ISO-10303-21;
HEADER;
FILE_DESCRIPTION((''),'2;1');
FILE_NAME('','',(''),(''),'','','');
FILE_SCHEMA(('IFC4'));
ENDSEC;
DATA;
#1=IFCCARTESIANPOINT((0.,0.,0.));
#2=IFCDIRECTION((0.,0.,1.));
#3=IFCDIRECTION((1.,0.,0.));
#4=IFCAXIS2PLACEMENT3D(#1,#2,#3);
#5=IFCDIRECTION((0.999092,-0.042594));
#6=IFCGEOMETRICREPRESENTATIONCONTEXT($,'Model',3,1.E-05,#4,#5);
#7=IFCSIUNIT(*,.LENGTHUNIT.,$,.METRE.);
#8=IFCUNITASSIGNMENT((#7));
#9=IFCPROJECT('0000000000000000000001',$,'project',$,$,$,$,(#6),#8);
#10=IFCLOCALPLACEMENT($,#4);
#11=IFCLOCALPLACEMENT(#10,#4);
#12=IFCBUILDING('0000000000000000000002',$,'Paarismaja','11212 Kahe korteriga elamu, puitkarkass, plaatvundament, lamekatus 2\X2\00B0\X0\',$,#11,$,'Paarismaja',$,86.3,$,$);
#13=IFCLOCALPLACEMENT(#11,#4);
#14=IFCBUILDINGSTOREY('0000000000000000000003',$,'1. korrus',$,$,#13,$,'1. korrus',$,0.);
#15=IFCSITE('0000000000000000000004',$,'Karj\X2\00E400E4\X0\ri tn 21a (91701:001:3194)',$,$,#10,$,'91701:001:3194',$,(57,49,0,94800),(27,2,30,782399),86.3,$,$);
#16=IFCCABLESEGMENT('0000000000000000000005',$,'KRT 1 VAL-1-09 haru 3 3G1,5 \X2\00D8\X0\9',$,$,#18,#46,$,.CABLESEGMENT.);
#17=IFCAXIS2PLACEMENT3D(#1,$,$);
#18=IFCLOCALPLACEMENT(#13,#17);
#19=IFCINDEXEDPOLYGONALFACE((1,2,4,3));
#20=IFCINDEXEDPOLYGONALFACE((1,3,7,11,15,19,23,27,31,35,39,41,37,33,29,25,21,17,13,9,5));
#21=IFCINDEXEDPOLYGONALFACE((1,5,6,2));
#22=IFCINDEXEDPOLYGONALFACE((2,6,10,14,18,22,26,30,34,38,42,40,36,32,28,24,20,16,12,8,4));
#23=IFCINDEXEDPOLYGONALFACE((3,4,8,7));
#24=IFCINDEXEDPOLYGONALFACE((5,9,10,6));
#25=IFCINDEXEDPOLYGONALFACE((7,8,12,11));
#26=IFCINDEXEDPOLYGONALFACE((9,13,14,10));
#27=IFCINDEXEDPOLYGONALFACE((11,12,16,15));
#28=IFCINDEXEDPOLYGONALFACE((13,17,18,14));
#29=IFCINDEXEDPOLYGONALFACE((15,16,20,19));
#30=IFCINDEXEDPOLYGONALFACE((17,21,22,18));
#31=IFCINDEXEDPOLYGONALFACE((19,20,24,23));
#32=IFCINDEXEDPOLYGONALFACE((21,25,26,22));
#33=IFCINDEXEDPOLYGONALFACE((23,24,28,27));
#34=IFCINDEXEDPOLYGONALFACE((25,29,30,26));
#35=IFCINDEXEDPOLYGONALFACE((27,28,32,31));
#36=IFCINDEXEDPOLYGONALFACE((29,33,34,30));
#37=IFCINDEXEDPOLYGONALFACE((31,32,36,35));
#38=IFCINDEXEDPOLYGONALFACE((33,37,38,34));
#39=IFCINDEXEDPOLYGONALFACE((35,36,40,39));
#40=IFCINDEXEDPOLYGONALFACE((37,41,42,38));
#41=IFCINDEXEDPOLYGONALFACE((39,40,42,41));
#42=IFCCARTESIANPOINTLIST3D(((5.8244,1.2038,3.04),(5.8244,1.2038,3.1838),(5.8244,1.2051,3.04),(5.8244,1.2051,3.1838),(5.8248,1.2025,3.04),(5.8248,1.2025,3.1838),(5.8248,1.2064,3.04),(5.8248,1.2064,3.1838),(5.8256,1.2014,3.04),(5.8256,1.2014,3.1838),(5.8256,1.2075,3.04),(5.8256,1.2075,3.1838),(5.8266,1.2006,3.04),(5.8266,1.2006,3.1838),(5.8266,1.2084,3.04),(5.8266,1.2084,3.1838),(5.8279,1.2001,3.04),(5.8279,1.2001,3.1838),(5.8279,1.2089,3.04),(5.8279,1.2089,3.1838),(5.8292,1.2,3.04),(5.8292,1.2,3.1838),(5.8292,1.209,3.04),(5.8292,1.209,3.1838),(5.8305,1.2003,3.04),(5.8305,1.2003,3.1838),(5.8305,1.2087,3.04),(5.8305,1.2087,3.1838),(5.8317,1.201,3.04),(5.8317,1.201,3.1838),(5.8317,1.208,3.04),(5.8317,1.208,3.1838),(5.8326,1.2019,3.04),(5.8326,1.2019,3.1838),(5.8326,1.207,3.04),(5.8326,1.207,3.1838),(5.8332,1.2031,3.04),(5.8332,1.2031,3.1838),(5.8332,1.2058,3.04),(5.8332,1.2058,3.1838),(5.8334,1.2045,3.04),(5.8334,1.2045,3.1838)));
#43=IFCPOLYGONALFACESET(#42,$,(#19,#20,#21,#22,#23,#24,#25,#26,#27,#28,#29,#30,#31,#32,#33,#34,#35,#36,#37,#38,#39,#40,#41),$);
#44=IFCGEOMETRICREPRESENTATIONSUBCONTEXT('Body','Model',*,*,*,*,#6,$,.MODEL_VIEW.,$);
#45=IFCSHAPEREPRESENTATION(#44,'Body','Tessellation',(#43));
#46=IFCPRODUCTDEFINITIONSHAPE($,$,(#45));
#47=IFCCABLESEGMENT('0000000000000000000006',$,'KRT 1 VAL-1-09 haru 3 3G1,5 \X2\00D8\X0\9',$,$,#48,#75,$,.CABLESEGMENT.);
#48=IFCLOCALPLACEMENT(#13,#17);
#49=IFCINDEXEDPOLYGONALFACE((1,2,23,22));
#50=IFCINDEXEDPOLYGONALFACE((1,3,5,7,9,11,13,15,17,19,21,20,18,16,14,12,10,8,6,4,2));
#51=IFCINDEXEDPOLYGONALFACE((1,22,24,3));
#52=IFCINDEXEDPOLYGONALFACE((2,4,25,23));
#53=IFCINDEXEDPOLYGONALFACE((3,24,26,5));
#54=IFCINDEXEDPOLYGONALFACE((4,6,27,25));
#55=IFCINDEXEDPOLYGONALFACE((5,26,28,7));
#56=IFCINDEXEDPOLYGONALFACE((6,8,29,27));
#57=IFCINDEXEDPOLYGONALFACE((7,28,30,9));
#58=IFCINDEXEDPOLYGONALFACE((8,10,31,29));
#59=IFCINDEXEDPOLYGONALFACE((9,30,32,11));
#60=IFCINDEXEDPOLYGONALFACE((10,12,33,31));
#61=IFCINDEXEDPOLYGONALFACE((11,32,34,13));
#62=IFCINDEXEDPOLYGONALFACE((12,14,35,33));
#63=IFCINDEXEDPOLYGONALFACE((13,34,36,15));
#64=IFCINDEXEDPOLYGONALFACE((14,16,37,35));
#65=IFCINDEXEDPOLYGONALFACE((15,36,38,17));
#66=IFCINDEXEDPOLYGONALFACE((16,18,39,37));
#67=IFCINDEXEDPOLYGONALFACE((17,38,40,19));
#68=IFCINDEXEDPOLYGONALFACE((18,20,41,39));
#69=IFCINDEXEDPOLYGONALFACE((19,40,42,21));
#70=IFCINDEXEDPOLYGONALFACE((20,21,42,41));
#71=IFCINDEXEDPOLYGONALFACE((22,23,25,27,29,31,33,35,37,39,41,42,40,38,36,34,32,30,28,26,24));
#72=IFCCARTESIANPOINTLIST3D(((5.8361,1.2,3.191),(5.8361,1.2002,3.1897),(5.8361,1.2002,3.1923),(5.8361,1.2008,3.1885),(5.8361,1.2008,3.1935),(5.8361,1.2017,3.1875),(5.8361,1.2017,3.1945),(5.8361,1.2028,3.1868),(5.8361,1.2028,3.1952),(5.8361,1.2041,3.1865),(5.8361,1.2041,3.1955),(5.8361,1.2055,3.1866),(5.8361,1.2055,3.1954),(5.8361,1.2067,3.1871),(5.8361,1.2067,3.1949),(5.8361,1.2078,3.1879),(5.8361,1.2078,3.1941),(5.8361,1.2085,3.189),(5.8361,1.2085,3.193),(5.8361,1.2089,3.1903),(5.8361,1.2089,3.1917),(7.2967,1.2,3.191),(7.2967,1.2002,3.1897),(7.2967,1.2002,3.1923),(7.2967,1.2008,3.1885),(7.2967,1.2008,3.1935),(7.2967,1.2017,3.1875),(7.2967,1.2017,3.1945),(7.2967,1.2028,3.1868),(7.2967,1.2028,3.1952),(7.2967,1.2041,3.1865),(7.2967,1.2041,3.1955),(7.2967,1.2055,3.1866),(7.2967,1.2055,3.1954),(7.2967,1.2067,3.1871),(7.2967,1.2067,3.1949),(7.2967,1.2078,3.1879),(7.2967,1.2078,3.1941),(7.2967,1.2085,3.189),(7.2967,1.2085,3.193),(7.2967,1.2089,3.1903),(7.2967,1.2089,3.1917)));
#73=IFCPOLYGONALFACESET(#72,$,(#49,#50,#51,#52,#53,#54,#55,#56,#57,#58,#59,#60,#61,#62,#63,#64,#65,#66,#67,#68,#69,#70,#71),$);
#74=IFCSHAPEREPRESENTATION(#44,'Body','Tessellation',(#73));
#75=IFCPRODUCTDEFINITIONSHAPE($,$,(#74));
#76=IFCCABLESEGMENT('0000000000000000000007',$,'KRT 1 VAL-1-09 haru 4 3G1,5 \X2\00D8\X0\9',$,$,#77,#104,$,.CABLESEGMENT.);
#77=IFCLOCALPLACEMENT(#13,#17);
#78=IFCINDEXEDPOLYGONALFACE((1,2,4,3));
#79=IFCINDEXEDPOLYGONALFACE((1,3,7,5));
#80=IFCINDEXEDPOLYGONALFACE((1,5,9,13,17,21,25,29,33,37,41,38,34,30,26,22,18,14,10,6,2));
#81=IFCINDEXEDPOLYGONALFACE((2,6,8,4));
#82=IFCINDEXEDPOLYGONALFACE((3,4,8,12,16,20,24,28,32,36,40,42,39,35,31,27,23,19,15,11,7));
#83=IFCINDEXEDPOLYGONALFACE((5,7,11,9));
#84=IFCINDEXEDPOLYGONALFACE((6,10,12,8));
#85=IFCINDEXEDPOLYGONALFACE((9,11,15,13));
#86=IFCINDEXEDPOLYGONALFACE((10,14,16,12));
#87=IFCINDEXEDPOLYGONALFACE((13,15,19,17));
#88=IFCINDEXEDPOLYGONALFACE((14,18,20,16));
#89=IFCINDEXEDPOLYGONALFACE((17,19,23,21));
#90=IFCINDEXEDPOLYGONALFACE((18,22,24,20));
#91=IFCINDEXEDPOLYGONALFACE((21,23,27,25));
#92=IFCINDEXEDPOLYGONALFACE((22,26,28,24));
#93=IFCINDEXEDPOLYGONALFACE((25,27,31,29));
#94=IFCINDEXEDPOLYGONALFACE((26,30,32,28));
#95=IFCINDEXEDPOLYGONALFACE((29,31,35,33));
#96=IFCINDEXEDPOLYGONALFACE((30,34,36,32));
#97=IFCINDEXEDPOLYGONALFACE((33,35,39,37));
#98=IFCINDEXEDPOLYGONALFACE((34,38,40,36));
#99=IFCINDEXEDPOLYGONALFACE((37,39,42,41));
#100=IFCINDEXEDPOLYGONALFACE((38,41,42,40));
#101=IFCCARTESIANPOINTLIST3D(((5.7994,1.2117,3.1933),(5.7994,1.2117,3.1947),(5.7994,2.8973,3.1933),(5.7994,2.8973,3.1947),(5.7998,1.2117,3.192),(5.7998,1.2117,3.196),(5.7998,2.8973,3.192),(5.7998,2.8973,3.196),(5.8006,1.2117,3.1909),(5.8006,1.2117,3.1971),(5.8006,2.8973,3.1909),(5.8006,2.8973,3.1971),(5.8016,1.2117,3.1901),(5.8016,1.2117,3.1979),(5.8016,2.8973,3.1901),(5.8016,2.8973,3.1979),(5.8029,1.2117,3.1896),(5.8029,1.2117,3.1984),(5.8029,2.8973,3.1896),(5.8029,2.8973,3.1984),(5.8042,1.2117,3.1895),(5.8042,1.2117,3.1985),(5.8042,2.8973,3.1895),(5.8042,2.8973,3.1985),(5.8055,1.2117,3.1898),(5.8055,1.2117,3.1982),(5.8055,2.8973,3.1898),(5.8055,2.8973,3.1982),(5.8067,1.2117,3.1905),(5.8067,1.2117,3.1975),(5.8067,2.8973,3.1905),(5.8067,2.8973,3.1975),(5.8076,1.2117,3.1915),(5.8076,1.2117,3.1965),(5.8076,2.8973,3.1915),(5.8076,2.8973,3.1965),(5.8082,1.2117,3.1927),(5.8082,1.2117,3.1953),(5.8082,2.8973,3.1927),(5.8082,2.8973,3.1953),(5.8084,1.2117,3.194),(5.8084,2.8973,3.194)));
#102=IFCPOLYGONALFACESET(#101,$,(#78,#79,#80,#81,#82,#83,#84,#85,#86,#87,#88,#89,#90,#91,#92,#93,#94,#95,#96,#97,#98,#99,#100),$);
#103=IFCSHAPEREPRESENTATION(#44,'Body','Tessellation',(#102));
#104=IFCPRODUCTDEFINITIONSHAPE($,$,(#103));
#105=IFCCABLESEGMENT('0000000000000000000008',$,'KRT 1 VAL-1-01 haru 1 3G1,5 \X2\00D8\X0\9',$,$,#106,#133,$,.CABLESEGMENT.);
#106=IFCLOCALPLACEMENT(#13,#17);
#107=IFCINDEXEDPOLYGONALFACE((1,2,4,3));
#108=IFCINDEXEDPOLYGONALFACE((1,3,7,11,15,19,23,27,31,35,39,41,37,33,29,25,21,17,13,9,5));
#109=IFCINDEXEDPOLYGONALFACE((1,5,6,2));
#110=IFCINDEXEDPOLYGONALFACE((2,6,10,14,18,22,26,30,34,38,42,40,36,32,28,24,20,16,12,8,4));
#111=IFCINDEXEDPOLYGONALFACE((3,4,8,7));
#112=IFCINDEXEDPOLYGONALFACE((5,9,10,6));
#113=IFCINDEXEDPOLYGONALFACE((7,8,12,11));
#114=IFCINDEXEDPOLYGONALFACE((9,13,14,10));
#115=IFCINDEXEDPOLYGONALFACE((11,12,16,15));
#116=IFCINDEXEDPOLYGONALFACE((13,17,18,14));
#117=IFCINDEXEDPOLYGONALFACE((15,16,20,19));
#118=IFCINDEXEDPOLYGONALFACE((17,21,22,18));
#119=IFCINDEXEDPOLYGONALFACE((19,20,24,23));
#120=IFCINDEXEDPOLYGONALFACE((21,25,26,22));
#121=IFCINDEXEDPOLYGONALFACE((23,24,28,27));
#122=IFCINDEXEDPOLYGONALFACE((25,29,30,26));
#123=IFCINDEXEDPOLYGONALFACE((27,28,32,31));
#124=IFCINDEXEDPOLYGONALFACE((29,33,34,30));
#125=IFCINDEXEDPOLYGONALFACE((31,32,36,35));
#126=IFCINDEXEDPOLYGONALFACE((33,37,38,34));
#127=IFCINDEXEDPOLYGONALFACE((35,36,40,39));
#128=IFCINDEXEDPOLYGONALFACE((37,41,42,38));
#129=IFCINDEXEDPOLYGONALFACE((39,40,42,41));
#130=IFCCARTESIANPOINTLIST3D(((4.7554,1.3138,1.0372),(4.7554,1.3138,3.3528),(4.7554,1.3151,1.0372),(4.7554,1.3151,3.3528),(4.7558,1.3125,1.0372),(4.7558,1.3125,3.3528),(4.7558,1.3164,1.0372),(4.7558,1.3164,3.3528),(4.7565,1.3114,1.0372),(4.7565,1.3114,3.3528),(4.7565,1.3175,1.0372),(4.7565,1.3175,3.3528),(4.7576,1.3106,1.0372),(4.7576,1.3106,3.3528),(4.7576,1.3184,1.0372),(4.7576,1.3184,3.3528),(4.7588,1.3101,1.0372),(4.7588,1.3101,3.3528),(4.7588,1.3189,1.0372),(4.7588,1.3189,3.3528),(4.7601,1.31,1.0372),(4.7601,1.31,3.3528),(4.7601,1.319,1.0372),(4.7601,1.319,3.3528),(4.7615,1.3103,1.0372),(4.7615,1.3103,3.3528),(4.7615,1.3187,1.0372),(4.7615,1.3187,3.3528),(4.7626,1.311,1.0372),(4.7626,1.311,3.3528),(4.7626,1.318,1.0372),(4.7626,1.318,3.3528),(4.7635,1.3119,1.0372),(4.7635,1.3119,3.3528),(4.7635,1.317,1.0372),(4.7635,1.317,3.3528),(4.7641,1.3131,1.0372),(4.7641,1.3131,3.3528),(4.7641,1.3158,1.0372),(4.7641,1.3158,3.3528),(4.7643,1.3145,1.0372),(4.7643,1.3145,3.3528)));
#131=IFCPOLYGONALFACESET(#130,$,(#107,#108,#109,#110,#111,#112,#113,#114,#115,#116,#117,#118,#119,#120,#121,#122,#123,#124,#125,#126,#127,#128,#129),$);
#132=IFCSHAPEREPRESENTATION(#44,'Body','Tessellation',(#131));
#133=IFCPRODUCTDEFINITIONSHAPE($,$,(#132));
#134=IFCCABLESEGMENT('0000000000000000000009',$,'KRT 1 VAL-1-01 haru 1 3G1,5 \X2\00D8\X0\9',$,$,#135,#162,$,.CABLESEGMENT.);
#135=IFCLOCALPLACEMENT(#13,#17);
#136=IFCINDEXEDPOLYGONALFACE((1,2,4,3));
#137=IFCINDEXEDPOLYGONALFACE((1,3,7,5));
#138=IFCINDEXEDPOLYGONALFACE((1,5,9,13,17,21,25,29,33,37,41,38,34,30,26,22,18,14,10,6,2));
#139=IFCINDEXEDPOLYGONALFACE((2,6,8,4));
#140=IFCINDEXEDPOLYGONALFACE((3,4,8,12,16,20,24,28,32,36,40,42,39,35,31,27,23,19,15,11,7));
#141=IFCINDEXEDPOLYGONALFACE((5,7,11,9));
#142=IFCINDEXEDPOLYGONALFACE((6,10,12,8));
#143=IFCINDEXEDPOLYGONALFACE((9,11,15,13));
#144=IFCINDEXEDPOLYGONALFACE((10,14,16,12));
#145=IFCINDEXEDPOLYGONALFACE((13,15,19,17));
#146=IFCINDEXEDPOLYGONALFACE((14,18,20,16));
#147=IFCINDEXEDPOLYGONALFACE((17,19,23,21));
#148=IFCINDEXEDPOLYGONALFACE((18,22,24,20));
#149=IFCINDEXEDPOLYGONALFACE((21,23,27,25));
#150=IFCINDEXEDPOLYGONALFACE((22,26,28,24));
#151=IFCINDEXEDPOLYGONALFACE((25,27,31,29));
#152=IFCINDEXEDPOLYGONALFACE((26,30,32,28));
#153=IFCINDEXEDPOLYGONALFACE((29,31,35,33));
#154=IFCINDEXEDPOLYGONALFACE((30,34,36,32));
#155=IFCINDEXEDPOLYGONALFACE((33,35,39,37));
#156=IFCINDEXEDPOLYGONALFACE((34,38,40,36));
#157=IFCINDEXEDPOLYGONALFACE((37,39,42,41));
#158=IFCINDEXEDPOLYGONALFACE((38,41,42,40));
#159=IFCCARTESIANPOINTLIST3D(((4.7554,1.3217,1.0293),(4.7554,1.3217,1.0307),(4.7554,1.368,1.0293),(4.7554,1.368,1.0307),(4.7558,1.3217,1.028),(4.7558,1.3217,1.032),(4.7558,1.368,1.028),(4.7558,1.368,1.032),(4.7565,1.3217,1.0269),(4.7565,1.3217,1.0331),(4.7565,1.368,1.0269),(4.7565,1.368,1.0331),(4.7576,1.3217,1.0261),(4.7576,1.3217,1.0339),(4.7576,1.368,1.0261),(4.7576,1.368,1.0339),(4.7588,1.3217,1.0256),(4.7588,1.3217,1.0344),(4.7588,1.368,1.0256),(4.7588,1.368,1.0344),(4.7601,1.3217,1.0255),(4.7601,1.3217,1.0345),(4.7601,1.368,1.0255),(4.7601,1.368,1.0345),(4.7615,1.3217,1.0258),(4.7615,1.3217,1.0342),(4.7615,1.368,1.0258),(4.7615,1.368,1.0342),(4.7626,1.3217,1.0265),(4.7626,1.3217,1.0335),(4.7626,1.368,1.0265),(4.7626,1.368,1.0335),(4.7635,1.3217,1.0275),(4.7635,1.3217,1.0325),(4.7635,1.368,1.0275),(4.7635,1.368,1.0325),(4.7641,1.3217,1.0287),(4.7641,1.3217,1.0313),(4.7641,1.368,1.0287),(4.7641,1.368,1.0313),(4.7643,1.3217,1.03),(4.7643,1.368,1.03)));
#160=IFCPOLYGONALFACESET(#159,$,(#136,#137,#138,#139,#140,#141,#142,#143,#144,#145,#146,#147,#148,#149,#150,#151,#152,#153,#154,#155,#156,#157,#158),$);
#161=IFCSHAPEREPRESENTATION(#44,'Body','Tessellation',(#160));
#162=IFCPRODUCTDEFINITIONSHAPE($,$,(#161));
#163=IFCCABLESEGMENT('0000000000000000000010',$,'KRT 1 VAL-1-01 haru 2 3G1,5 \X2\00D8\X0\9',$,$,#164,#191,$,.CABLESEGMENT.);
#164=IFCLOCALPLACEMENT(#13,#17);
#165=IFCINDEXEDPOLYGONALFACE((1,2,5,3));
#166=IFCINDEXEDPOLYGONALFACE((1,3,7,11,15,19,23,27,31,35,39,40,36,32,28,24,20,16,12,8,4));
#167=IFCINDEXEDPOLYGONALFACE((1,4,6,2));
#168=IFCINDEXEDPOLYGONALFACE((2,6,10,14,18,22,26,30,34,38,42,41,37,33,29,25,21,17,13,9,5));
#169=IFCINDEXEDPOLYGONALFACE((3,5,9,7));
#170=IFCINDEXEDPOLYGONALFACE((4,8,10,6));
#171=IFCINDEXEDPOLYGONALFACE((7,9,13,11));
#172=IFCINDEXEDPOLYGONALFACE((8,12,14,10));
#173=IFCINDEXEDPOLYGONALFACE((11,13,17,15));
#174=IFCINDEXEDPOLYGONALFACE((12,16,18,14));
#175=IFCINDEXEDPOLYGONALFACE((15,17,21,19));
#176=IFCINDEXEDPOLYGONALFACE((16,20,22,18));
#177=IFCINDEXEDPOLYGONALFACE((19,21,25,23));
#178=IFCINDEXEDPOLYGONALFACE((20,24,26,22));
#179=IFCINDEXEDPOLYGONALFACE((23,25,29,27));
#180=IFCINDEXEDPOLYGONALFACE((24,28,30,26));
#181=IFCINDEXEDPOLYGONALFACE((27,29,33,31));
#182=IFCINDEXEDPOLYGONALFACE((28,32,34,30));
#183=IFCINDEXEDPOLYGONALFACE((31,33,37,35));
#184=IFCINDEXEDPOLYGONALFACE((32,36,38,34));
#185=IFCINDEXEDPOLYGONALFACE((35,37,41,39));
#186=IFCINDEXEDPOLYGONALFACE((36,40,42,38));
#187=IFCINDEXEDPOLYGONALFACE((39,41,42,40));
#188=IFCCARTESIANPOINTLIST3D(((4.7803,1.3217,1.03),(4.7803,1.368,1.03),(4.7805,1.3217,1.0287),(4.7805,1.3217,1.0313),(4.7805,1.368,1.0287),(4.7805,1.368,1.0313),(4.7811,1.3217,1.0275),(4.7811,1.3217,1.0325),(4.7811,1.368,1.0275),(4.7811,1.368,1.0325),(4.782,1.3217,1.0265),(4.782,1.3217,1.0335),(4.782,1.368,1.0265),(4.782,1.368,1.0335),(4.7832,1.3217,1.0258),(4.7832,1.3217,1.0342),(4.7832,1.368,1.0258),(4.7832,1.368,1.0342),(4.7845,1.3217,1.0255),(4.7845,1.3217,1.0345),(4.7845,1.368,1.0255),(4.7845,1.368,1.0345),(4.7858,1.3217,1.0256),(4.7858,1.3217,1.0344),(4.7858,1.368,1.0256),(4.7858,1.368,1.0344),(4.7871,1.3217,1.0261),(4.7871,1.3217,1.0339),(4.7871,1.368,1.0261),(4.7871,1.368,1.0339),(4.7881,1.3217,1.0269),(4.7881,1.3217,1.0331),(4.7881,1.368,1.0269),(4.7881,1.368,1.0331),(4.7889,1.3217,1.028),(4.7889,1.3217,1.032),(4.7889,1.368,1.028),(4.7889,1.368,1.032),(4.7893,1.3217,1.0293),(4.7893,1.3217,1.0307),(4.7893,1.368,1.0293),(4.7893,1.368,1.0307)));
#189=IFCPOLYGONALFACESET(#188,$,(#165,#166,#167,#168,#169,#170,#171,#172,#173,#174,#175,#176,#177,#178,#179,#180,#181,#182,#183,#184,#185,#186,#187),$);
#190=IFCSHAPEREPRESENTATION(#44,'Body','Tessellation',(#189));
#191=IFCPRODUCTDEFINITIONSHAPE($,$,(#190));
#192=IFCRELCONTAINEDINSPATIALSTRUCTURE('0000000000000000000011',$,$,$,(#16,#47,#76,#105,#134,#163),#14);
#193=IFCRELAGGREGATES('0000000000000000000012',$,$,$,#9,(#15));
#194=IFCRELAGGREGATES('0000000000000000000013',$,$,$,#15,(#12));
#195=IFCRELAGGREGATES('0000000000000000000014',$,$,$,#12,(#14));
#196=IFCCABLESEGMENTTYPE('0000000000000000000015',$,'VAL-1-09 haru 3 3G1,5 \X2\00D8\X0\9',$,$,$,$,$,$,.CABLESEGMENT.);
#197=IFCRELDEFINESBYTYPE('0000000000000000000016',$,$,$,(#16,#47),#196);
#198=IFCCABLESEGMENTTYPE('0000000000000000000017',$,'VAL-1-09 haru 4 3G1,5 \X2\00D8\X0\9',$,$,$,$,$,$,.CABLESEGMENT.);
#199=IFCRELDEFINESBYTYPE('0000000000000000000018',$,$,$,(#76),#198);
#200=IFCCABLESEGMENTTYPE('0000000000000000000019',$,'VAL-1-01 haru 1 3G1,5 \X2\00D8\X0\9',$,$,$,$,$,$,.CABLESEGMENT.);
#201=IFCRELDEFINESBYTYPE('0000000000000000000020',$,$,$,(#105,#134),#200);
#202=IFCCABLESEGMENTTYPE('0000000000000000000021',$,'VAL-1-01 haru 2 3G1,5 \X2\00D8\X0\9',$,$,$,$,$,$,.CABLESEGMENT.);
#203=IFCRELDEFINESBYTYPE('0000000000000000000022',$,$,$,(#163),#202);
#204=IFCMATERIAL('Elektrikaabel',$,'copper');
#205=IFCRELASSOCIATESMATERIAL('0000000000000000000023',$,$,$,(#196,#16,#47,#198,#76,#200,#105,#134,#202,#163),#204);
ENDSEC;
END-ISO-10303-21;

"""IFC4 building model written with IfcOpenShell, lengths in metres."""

from ifc_helpers import new_model, si_unit, direction, frame, origin_with_axes, place, context, subcontext, project, spatial, circle, extrude, material, type_object, element, save


model = new_model("IFC4")

# Units and contexts
model_context = context("Model", 3, precision=1e-05, world=origin_with_axes(), true_north=direction((0.999092, -0.042594)))
body_context = subcontext(model_context, "Body", "Model", "MODEL_VIEW")
ifc_project = project(units=[si_unit("LENGTHUNIT", "METRE")], contexts=[model_context])

# Site, building, storey
site_placement = place(None, origin_with_axes())
site = spatial("IfcSite", under=ifc_project, at=site_placement, Name="Karjääri tn 21a (91701:001:3194)", LongName="91701:001:3194", RefLatitude=(57, 49, 0, 94800), RefLongitude=(27, 2, 30, 782399), RefElevation=86.3)
building_placement = place(site_placement, origin_with_axes())
building = spatial("IfcBuilding", under=site, at=building_placement, Name="Paarismaja", Description="11212 Kahe korteriga elamu, puitkarkass, plaatvundament, lamekatus 2°", LongName="Paarismaja", ElevationOfRefHeight=86.3)
storey_placement = place(building_placement, origin_with_axes())
storey = spatial("IfcBuildingStorey", under=building, at=storey_placement, Name="1. korrus", LongName="1. korrus", Elevation=0.0)

# Shared definitions
ifc_material_1 = material(Name="Elektrikaabel", Category="copper")

# Cable segments
cable_segment_type_1 = type_object("IfcCableSegmentType", Name="VAL-1-09 haru 3 3G1,5 Ø9", PredefinedType="CABLESEGMENT", material=ifc_material_1)
cable_segment_1_placement = place(storey_placement, frame((5.8289, 1.2045, 3.04), z_axis=(0.0, 0.0, 1.0), x_axis=(1.0, 0.0, 0.0)))
element("IfcCableSegment", 1, at=cable_segment_1_placement, inside=storey, type_object=cable_segment_type_1, material=ifc_material_1, Name="KRT 1 VAL-1-09 haru 3 3G1,5 Ø9", PredefinedType="CABLESEGMENT", context=body_context, shape_type="SweptSolid", body=[
    extrude(circle(Radius=0.0045), origin_with_axes(), (0.0, 0.0, 1.0), 0.1438),
])
cable_segment_2_placement = place(storey_placement, frame((5.8361, 1.2045, 3.191), z_axis=(1.0, 0.0, 0.0), x_axis=(0.0, -1.0, 0.0)))
element("IfcCableSegment", 2, at=cable_segment_2_placement, inside=storey, type_object=cable_segment_type_1, material=ifc_material_1, Name="KRT 1 VAL-1-09 haru 3 3G1,5 Ø9", PredefinedType="CABLESEGMENT", context=body_context, shape_type="SweptSolid", body=[
    extrude(circle(Radius=0.0045), origin_with_axes(), (0.0, 0.0, 1.0), 1.4606),
])
cable_segment_type_2 = type_object("IfcCableSegmentType", Name="VAL-1-09 haru 4 3G1,5 Ø9", PredefinedType="CABLESEGMENT", material=ifc_material_1)
cable_segment_3_placement = place(storey_placement, frame((5.8039, 1.2117, 3.194), z_axis=(0.0, 1.0, 0.0), x_axis=(1.0, 0.0, 0.0)))
element("IfcCableSegment", 3, at=cable_segment_3_placement, inside=storey, type_object=cable_segment_type_2, material=ifc_material_1, Name="KRT 1 VAL-1-09 haru 4 3G1,5 Ø9", PredefinedType="CABLESEGMENT", context=body_context, shape_type="SweptSolid", body=[
    extrude(circle(Radius=0.0045), origin_with_axes(), (0.0, 0.0, 1.0), 1.6856),
])
cable_segment_type_3 = type_object("IfcCableSegmentType", Name="VAL-1-01 haru 1 3G1,5 Ø9", PredefinedType="CABLESEGMENT", material=ifc_material_1)
cable_segment_4_placement = place(storey_placement, frame((4.7598, 1.3145, 3.3528), z_axis=(0.0, 0.0, -1.0), x_axis=(1.0, 0.0, 0.0)))
element("IfcCableSegment", 4, at=cable_segment_4_placement, inside=storey, type_object=cable_segment_type_3, material=ifc_material_1, Name="KRT 1 VAL-1-01 haru 1 3G1,5 Ø9", PredefinedType="CABLESEGMENT", context=body_context, shape_type="SweptSolid", body=[
    extrude(circle(Radius=0.0045), origin_with_axes(), (0.0, 0.0, 1.0), 2.3156),
])
cable_segment_5_placement = place(storey_placement, frame((4.7598, 1.3217, 1.03), z_axis=(0.0, 1.0, 0.0), x_axis=(1.0, 0.0, 0.0)))
element("IfcCableSegment", 5, at=cable_segment_5_placement, inside=storey, type_object=cable_segment_type_3, material=ifc_material_1, Name="KRT 1 VAL-1-01 haru 1 3G1,5 Ø9", PredefinedType="CABLESEGMENT", context=body_context, shape_type="SweptSolid", body=[
    extrude(circle(Radius=0.0045), origin_with_axes(), (0.0, 0.0, 1.0), 0.0463),
])
cable_segment_type_4 = type_object("IfcCableSegmentType", Name="VAL-1-01 haru 2 3G1,5 Ø9", PredefinedType="CABLESEGMENT", material=ifc_material_1)
cable_segment_6_placement = place(storey_placement, frame((4.7848, 1.368, 1.03), z_axis=(0.0, -1.0, 0.0), x_axis=(-1.0, 0.0, 0.0)))
element("IfcCableSegment", 6, at=cable_segment_6_placement, inside=storey, type_object=cable_segment_type_4, material=ifc_material_1, Name="KRT 1 VAL-1-01 haru 2 3G1,5 Ø9", PredefinedType="CABLESEGMENT", context=body_context, shape_type="SweptSolid", body=[
    extrude(circle(Radius=0.0045), origin_with_axes(), (0.0, 0.0, 1.0), 0.0463),
])

save(model, "model.ifc")
